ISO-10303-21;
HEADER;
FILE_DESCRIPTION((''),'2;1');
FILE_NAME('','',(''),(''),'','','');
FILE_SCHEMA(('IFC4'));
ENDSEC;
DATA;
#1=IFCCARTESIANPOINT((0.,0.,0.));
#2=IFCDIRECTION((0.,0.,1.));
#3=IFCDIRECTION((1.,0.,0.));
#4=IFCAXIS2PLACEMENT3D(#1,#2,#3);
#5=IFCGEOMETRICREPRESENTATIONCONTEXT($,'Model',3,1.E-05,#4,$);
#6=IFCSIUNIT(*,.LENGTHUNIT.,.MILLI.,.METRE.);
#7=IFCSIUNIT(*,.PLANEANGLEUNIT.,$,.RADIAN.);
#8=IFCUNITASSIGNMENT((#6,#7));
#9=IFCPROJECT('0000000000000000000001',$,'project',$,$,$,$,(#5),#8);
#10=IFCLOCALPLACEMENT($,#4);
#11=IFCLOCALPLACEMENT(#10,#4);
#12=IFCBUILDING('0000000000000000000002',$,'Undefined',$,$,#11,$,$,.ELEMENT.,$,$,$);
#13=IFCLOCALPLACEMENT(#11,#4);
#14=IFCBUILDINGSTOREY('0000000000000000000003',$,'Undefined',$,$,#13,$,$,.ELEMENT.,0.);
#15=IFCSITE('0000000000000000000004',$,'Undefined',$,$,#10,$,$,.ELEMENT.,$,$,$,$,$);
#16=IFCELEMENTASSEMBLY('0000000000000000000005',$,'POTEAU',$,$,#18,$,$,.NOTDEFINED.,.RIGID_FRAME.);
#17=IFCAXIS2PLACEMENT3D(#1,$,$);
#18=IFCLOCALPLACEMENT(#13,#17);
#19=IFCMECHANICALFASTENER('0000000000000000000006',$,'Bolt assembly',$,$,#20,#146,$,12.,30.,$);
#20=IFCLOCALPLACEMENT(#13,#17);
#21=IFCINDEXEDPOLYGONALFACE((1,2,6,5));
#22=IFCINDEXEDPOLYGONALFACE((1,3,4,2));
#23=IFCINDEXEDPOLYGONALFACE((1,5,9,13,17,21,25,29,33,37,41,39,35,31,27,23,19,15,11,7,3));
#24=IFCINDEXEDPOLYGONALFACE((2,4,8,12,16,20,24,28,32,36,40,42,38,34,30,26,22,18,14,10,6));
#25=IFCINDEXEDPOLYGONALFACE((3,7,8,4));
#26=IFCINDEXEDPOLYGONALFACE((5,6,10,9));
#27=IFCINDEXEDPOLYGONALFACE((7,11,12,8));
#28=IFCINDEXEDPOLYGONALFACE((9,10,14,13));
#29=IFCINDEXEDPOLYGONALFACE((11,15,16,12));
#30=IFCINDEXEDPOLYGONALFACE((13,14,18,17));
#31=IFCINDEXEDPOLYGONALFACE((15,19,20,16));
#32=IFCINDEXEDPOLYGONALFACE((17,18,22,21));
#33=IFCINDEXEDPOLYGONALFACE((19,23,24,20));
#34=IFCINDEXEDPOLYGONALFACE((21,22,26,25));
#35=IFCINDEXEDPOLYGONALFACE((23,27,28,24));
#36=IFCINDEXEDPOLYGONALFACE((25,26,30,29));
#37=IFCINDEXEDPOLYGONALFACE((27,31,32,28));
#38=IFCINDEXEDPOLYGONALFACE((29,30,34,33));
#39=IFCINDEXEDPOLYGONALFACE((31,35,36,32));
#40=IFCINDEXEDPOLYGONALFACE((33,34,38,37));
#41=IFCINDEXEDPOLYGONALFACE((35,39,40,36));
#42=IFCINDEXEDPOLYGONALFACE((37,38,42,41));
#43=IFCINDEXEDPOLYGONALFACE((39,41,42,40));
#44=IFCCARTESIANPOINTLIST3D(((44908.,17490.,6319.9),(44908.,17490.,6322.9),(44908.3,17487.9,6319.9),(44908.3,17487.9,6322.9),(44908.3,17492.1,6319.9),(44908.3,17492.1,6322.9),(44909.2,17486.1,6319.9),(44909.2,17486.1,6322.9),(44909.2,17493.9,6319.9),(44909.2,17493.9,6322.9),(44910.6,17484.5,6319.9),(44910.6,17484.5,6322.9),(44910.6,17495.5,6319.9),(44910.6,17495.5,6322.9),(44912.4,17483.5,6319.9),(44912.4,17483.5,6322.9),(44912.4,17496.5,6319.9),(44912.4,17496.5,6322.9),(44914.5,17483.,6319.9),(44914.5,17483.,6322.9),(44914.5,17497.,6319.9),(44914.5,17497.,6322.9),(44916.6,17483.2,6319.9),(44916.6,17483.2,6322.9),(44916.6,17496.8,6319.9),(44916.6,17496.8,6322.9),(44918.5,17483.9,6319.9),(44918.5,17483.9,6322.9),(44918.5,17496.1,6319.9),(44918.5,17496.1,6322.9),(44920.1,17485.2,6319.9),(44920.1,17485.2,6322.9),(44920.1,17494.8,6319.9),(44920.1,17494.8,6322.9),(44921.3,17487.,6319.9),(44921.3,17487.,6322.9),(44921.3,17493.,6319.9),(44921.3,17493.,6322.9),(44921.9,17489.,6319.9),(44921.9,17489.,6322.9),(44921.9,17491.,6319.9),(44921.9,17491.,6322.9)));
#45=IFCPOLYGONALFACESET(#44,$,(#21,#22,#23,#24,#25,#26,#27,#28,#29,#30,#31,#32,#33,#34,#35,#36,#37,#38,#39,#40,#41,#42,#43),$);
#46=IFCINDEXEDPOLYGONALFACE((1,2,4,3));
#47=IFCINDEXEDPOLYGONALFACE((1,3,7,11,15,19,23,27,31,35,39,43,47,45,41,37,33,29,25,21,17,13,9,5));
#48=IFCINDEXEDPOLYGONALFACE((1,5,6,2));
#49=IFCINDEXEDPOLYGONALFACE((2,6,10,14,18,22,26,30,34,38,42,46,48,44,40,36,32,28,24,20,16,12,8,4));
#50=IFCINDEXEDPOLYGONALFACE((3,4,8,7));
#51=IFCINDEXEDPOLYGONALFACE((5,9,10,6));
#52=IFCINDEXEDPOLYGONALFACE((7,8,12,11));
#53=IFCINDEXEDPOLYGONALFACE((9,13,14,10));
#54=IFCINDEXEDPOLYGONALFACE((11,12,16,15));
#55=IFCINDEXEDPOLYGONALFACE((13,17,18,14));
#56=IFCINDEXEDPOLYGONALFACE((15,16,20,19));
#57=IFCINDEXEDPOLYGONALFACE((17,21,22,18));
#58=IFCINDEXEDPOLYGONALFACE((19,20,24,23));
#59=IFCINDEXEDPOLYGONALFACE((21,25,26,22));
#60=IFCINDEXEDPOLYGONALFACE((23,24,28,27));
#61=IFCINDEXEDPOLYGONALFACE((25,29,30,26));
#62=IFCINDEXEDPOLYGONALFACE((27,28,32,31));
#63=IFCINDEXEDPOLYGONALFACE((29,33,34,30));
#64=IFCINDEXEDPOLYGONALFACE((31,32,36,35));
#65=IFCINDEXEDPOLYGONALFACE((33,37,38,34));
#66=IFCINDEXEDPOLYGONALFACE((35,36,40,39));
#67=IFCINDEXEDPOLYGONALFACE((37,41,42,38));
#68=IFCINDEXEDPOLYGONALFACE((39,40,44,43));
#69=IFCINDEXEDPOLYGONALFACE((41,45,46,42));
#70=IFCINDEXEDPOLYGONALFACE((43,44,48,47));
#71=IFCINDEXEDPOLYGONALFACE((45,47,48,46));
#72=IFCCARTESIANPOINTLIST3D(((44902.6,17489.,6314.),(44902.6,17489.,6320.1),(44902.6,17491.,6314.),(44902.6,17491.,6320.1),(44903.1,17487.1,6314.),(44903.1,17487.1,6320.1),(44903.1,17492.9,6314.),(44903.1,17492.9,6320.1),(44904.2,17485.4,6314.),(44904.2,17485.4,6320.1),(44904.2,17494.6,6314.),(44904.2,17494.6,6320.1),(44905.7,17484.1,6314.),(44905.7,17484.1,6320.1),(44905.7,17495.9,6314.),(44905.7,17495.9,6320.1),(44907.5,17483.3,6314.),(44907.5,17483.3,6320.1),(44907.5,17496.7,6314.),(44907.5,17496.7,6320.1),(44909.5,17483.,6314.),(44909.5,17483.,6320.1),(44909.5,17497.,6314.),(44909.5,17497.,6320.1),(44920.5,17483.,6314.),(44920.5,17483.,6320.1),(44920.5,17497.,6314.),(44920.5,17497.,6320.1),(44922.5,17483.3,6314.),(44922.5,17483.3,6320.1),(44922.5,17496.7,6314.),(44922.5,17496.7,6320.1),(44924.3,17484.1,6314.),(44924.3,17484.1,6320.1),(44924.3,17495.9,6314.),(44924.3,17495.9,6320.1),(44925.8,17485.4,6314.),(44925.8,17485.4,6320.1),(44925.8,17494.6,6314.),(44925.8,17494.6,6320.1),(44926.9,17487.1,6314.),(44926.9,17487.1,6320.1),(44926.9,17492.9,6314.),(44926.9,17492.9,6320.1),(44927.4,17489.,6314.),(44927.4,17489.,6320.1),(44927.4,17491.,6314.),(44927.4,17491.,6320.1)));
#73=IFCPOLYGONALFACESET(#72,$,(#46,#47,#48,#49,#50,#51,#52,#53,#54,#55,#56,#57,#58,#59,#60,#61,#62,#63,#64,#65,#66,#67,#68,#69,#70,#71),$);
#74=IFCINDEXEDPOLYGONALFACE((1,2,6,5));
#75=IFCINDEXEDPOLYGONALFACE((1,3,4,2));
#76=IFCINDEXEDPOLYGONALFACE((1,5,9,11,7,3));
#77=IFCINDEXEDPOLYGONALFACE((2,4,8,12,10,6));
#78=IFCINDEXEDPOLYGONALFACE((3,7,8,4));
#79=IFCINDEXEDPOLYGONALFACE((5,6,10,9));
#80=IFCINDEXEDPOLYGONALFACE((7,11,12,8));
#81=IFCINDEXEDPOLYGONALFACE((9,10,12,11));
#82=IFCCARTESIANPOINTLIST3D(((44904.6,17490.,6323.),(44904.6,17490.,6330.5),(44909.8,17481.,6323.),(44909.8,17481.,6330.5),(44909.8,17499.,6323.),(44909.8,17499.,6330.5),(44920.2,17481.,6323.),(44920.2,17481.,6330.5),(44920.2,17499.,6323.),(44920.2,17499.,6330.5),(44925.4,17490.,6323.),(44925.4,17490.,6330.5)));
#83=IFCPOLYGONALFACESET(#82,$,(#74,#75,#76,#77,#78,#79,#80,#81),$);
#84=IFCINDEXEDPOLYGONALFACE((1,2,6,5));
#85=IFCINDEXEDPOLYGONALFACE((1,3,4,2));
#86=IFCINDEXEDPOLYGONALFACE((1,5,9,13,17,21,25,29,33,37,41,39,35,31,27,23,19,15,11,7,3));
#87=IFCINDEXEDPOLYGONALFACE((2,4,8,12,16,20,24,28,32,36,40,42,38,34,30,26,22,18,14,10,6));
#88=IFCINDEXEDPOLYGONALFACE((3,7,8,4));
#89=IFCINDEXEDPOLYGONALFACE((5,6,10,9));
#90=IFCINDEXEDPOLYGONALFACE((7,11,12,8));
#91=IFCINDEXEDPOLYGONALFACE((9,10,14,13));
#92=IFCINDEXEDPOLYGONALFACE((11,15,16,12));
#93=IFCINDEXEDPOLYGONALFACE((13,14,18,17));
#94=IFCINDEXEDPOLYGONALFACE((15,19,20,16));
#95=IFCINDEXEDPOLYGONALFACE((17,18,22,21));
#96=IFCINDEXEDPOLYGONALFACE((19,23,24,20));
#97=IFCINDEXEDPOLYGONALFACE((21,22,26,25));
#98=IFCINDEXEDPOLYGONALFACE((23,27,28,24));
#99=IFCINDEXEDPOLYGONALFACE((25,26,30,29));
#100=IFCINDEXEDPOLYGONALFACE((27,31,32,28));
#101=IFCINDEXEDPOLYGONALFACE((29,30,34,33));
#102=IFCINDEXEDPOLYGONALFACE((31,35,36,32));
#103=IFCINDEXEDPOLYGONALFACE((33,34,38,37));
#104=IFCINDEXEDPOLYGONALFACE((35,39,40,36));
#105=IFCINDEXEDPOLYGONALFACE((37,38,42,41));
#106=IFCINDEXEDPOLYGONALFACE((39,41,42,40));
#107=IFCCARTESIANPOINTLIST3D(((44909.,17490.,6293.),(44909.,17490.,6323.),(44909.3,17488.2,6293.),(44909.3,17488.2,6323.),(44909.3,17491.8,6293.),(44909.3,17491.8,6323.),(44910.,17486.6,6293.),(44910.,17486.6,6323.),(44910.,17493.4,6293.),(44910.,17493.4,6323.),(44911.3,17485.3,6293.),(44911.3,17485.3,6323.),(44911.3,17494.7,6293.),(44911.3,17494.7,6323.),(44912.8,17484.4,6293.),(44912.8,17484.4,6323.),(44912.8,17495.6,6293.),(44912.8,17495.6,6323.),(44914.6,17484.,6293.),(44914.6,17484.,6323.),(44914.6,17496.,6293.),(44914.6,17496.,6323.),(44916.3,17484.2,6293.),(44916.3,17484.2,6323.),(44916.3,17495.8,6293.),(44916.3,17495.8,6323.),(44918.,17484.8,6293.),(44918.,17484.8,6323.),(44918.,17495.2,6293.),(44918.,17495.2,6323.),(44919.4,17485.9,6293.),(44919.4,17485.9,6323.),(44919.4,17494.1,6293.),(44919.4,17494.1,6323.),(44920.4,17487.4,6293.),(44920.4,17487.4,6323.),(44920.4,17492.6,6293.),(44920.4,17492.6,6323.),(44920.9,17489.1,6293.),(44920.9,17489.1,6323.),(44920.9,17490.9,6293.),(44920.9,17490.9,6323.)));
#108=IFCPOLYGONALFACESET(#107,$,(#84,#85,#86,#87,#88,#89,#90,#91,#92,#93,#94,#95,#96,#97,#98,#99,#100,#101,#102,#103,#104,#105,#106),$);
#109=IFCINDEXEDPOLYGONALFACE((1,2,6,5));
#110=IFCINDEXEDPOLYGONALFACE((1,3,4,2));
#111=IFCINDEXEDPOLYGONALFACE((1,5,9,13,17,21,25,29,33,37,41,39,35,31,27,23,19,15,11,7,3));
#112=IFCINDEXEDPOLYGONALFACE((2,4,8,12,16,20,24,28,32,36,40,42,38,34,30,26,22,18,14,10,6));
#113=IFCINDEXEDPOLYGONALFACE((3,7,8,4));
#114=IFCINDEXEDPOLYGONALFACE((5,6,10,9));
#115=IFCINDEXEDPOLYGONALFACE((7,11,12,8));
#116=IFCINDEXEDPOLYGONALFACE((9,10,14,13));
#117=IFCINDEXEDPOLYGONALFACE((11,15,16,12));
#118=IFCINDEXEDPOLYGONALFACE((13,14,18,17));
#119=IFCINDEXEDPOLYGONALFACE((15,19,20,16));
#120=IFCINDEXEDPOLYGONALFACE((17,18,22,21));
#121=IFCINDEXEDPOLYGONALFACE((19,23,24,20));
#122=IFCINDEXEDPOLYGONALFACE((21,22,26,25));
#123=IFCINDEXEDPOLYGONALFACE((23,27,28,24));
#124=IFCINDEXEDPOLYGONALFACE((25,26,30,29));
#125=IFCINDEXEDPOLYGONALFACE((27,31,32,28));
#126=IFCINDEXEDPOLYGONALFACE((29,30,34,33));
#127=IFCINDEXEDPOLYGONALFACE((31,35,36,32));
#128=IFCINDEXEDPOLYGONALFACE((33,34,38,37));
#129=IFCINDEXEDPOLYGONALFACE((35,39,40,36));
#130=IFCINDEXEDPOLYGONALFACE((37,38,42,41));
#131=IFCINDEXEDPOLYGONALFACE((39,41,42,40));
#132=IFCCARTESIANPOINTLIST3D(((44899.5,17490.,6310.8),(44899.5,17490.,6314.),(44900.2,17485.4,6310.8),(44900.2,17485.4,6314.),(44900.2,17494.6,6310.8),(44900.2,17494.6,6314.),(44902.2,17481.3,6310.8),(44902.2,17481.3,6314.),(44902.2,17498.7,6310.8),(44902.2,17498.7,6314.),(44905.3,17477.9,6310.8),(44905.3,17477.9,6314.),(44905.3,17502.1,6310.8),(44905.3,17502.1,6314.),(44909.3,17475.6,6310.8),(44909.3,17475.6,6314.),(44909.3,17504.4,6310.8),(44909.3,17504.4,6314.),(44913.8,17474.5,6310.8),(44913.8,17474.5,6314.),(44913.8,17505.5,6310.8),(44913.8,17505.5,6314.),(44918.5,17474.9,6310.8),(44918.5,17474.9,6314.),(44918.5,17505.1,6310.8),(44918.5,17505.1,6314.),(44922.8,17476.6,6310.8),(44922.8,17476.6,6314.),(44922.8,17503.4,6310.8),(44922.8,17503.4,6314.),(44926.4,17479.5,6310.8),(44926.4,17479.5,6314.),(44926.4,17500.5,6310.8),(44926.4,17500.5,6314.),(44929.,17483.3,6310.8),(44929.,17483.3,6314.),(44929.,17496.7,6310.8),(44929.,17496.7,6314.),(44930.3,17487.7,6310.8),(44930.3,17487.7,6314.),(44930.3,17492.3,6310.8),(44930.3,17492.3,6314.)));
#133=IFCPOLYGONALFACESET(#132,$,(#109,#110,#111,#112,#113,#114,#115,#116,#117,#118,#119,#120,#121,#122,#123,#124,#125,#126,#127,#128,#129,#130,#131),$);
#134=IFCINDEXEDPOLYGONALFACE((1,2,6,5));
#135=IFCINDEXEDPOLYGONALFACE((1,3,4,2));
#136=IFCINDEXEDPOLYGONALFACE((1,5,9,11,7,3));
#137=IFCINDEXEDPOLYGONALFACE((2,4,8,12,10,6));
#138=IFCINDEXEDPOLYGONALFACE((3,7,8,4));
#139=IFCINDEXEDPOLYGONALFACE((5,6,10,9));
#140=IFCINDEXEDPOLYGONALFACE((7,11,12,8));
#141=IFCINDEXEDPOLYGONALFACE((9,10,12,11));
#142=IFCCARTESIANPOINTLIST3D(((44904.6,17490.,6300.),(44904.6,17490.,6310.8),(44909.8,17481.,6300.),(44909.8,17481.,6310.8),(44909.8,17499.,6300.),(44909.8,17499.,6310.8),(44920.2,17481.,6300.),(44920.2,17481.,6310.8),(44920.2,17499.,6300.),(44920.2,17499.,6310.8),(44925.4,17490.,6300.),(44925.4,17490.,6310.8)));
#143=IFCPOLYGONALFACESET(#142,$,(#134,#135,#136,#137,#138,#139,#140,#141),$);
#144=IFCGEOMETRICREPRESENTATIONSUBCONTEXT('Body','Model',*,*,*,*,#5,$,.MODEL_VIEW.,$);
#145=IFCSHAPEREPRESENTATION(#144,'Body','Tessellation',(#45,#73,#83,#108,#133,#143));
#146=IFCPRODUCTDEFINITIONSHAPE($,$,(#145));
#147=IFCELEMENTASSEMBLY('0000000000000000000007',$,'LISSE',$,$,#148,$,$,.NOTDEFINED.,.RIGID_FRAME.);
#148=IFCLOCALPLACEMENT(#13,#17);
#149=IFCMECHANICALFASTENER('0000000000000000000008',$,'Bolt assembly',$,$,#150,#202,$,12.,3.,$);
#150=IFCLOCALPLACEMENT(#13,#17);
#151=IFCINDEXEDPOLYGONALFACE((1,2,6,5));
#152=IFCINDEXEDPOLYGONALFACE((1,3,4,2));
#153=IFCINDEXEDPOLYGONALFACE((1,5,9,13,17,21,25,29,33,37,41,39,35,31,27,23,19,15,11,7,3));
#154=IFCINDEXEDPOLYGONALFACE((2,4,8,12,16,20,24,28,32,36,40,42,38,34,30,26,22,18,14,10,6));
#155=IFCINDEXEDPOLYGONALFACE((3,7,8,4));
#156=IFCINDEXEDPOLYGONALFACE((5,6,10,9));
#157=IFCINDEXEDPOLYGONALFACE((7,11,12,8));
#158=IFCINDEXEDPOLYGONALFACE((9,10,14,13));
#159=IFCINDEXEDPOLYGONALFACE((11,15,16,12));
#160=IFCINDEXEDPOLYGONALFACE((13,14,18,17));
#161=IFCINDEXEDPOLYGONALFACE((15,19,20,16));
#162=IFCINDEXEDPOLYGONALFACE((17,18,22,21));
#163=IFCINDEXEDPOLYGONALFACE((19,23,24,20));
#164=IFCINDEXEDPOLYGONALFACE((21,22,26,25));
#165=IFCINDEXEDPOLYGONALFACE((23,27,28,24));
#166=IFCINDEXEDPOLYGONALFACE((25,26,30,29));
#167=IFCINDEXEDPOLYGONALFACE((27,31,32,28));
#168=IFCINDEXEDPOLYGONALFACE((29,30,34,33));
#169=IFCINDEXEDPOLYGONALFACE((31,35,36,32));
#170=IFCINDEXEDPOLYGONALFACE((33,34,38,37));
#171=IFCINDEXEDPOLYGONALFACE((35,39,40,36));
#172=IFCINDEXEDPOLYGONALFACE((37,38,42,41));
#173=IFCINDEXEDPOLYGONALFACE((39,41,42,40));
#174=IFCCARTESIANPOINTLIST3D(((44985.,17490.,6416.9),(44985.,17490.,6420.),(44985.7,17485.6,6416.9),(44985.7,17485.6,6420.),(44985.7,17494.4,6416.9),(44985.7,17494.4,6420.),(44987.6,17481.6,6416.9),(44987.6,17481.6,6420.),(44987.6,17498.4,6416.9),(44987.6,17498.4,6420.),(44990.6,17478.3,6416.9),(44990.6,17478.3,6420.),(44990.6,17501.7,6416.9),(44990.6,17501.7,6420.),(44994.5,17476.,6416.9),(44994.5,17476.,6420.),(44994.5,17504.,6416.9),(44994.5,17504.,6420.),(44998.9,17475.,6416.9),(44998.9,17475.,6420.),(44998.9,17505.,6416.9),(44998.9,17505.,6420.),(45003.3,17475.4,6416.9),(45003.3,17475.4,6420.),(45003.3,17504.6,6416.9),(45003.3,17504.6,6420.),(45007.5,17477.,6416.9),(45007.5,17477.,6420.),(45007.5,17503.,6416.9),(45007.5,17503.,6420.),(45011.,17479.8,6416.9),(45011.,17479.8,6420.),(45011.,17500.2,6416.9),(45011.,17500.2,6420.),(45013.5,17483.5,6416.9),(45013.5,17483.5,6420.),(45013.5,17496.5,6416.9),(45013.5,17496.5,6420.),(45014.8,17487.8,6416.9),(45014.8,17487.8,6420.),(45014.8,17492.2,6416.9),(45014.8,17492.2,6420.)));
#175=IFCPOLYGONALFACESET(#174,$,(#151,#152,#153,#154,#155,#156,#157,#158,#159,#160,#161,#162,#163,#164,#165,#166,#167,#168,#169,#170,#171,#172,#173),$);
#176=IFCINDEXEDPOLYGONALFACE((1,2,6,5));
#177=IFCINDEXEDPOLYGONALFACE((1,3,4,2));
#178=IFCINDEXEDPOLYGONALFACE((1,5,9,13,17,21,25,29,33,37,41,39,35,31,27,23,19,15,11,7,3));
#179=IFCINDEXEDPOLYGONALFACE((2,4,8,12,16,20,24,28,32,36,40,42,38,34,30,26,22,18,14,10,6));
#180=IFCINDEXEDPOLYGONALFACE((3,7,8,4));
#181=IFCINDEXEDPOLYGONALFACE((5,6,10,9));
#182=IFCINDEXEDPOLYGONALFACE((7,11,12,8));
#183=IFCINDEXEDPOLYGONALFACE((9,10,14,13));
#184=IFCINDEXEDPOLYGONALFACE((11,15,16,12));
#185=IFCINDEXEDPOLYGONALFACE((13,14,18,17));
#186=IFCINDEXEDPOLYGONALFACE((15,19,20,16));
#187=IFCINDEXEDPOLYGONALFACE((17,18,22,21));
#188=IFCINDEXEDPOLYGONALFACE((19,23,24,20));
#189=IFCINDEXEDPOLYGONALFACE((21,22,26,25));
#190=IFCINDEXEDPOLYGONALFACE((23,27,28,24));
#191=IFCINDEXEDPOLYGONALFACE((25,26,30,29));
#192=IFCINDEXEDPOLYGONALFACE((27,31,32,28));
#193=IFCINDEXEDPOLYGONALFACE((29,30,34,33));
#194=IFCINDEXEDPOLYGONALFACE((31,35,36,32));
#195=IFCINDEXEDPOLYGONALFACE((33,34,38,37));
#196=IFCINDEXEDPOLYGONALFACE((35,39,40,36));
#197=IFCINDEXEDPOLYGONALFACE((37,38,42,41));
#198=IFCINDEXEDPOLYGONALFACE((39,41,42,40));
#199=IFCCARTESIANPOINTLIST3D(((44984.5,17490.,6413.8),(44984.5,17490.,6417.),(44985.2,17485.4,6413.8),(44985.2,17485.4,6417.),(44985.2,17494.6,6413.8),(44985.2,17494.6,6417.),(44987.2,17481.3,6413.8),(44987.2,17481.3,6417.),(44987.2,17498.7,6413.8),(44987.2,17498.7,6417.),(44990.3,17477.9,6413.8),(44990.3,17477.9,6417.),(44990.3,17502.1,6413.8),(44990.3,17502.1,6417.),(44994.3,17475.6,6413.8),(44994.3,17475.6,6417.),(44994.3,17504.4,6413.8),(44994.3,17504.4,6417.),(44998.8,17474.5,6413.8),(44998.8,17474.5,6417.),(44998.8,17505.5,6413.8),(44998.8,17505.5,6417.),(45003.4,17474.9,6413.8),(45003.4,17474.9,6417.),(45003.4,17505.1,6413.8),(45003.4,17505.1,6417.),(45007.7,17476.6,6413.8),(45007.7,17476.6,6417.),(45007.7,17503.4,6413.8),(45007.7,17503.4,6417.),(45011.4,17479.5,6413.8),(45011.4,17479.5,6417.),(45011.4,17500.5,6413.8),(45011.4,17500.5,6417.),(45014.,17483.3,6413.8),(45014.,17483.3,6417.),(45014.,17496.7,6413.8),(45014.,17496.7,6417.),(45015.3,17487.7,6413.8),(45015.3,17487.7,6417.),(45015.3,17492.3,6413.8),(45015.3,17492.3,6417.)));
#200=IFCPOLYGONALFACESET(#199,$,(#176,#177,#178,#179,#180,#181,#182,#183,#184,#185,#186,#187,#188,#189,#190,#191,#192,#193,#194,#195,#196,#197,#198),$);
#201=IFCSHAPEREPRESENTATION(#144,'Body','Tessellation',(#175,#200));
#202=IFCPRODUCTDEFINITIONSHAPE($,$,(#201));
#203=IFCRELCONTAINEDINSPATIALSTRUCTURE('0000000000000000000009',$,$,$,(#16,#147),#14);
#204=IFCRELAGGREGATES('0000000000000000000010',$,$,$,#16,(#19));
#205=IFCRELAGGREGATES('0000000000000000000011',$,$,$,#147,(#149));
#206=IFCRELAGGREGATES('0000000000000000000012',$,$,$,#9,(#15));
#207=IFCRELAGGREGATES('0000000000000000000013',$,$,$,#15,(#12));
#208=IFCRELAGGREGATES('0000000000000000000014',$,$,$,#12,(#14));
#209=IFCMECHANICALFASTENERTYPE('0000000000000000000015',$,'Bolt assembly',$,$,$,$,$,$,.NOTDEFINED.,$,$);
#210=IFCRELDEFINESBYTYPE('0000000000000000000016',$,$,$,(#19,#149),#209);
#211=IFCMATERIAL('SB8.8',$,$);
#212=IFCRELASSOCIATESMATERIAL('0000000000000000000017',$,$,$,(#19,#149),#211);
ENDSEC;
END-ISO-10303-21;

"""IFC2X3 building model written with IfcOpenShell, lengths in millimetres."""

from ifc_helpers import new_model, si_unit, frame, frame_2d, origin_with_axes, origin_2d_with_axis, place, context, subcontext, project, spatial, polyline, circle_curve, parameter, trimmed, segment, composite_curve, circle, outline, extrude, source, transform, mapped, material, type_object, element, aggregate, save


model = new_model("IFC2X3")

# Units and contexts
model_context = context("Model", 3, precision=1e-05, world=origin_with_axes())
body_context = subcontext(model_context, "Body", "Model", "MODEL_VIEW")
ifc_project = project(units=[si_unit("LENGTHUNIT", "METRE", prefix="MILLI"), si_unit("PLANEANGLEUNIT", "RADIAN")], contexts=[model_context])

# Site, building, storey
site_placement = place(None, origin_with_axes())
site = spatial("IfcSite", under=ifc_project, at=site_placement, Name="Undefined", CompositionType="ELEMENT")
building_placement = place(site_placement, origin_with_axes())
building = spatial("IfcBuilding", under=site, at=building_placement, Name="Undefined", CompositionType="ELEMENT")
storey_placement = place(building_placement, origin_with_axes())
storey = spatial("IfcBuildingStorey", under=building, at=storey_placement, Name="Undefined", CompositionType="ELEMENT", Elevation=0.0)

# Element assembly
assembly_1_placement = place(storey_placement, origin_with_axes())
assembly_1 = element("IfcElementAssembly", 1, at=assembly_1_placement, inside=storey, Name="POTEAU", AssemblyPlace="NOTDEFINED", PredefinedType="RIGID_FRAME")

# Mechanical fastener
ifc_material_1 = material(Name="SB8.8")
mechanical_fastener_type = type_object("IfcMechanicalFastenerType", Name="Bolt assembly")
shared_shape_1 = source(origin_with_axes(), body_context, "Body", "SweptSolid", [
    extrude(circle(Radius=7.0, at=origin_2d_with_axis()), frame((0.0, -2.9, 0.0), z_axis=(0.0, 1.0, 0.0), x_axis=(1.0, 0.0, 0.0)), (0.0, 0.0, 1.0), 3.0),
    extrude(outline(composite_curve([segment(polyline([(-5.5, 7.0), (5.5, 7.0)]), True, "CONTINUOUS"), segment(trimmed(circle_curve(frame_2d((5.5, 0.0), x_axis=(0.0, 1.0)), 7.0), [parameter(0.0)], [parameter(3.141593)], False, "PARAMETER"), True, "CONTINUOUS"), segment(polyline([(5.5, -7.0), (-5.5, -7.0)]), True, "CONTINUOUS"), segment(trimmed(circle_curve(frame_2d((-5.5, 0.0), x_axis=(0.0, -1.0)), 7.0), [parameter(0.0)], [parameter(3.141593)], False, "PARAMETER"), True, "DISCONTINUOUS")], self_intersect=False)), frame((0.0, -0.1, 0.0), z_axis=(0.0, 1.0, 0.0), x_axis=(1.0, 0.0, 0.0)), (0.0, 0.0, 1.0), 6.1),
    extrude(outline(polyline([(10.4, 0.0), (5.2, 9.0), (-5.2, 9.0), (-10.4, 0.0), (-5.2, -9.0), (5.2, -9.0), (10.4, 0.0)])), frame((0.0, -10.5, 0.0), z_axis=(0.0, 1.0, 0.0), x_axis=(1.0, 0.0, 0.0)), (0.0, 0.0, 1.0), 7.5),
    extrude(circle(Radius=6.0, at=origin_2d_with_axis()), frame((0.0, -3.0, 0.0), z_axis=(0.0, 1.0, 0.0), x_axis=(1.0, 0.0, 0.0)), (0.0, 0.0, 1.0), 30.0),
    extrude(circle(Radius=15.5, at=origin_2d_with_axis()), frame((0.0, 6.0, 0.0), z_axis=(0.0, 1.0, 0.0), x_axis=(1.0, 0.0, 0.0)), (0.0, 0.0, 1.0), 3.2),
    extrude(outline(polyline([(10.4, 0.0), (5.2, 9.0), (-5.2, 9.0), (-10.4, 0.0), (-5.2, -9.0), (5.2, -9.0), (10.4, 0.0)])), frame((0.0, 9.2, 0.0), z_axis=(0.0, 1.0, 0.0), x_axis=(1.0, 0.0, 0.0)), (0.0, 0.0, 1.0), 10.8),
])
mechanical_fastener_1_placement = place(assembly_1_placement, frame((44915.0, 17490.0, 6320.0), z_axis=(0.0, -1.0, 0.0), x_axis=(-1.0, 0.0, 0.0)))
mechanical_fastener_1 = element("IfcMechanicalFastener", 2, at=mechanical_fastener_1_placement, type_object=mechanical_fastener_type, material=ifc_material_1, Name="Bolt assembly", NominalDiameter=12.0, NominalLength=30.0, context=body_context, shape_type="MappedRepresentation", body=[
    mapped(shared_shape_1, transform((0.0, 0.0, 0.0))),
])
aggregate(assembly_1, [mechanical_fastener_1])

# Element assembly, mechanical fastener
assembly_2_placement = place(storey_placement, origin_with_axes())
assembly_2 = element("IfcElementAssembly", 3, at=assembly_2_placement, inside=storey, Name="LISSE", AssemblyPlace="NOTDEFINED", PredefinedType="RIGID_FRAME")
shared_shape_2 = source(origin_with_axes(), body_context, "Body", "SweptSolid", [
    extrude(circle(Radius=15.0, at=origin_2d_with_axis()), frame((0.0, 0.0, 0.0), z_axis=(0.0, 1.0, 0.0), x_axis=(1.0, 0.0, 0.0)), (0.0, 0.0, 1.0), 3.1),
    extrude(circle(Radius=15.5, at=origin_2d_with_axis()), frame((0.0, 3.0, 0.0), z_axis=(0.0, 1.0, 0.0), x_axis=(1.0, 0.0, 0.0)), (0.0, 0.0, 1.0), 3.2),
])
mechanical_fastener_2_placement = place(assembly_2_placement, frame((45000.0, 17490.0, 6420.0), z_axis=(0.0, -1.0, 0.0), x_axis=(-1.0, 0.0, 0.0)))
mechanical_fastener_2 = element("IfcMechanicalFastener", 4, at=mechanical_fastener_2_placement, type_object=mechanical_fastener_type, material=ifc_material_1, Name="Bolt assembly", NominalDiameter=12.0, NominalLength=3.0, context=body_context, shape_type="MappedRepresentation", body=[
    mapped(shared_shape_2, transform((0.0, 0.0, 0.0))),
])
aggregate(assembly_2, [mechanical_fastener_2])

save(model, "model.ifc")
